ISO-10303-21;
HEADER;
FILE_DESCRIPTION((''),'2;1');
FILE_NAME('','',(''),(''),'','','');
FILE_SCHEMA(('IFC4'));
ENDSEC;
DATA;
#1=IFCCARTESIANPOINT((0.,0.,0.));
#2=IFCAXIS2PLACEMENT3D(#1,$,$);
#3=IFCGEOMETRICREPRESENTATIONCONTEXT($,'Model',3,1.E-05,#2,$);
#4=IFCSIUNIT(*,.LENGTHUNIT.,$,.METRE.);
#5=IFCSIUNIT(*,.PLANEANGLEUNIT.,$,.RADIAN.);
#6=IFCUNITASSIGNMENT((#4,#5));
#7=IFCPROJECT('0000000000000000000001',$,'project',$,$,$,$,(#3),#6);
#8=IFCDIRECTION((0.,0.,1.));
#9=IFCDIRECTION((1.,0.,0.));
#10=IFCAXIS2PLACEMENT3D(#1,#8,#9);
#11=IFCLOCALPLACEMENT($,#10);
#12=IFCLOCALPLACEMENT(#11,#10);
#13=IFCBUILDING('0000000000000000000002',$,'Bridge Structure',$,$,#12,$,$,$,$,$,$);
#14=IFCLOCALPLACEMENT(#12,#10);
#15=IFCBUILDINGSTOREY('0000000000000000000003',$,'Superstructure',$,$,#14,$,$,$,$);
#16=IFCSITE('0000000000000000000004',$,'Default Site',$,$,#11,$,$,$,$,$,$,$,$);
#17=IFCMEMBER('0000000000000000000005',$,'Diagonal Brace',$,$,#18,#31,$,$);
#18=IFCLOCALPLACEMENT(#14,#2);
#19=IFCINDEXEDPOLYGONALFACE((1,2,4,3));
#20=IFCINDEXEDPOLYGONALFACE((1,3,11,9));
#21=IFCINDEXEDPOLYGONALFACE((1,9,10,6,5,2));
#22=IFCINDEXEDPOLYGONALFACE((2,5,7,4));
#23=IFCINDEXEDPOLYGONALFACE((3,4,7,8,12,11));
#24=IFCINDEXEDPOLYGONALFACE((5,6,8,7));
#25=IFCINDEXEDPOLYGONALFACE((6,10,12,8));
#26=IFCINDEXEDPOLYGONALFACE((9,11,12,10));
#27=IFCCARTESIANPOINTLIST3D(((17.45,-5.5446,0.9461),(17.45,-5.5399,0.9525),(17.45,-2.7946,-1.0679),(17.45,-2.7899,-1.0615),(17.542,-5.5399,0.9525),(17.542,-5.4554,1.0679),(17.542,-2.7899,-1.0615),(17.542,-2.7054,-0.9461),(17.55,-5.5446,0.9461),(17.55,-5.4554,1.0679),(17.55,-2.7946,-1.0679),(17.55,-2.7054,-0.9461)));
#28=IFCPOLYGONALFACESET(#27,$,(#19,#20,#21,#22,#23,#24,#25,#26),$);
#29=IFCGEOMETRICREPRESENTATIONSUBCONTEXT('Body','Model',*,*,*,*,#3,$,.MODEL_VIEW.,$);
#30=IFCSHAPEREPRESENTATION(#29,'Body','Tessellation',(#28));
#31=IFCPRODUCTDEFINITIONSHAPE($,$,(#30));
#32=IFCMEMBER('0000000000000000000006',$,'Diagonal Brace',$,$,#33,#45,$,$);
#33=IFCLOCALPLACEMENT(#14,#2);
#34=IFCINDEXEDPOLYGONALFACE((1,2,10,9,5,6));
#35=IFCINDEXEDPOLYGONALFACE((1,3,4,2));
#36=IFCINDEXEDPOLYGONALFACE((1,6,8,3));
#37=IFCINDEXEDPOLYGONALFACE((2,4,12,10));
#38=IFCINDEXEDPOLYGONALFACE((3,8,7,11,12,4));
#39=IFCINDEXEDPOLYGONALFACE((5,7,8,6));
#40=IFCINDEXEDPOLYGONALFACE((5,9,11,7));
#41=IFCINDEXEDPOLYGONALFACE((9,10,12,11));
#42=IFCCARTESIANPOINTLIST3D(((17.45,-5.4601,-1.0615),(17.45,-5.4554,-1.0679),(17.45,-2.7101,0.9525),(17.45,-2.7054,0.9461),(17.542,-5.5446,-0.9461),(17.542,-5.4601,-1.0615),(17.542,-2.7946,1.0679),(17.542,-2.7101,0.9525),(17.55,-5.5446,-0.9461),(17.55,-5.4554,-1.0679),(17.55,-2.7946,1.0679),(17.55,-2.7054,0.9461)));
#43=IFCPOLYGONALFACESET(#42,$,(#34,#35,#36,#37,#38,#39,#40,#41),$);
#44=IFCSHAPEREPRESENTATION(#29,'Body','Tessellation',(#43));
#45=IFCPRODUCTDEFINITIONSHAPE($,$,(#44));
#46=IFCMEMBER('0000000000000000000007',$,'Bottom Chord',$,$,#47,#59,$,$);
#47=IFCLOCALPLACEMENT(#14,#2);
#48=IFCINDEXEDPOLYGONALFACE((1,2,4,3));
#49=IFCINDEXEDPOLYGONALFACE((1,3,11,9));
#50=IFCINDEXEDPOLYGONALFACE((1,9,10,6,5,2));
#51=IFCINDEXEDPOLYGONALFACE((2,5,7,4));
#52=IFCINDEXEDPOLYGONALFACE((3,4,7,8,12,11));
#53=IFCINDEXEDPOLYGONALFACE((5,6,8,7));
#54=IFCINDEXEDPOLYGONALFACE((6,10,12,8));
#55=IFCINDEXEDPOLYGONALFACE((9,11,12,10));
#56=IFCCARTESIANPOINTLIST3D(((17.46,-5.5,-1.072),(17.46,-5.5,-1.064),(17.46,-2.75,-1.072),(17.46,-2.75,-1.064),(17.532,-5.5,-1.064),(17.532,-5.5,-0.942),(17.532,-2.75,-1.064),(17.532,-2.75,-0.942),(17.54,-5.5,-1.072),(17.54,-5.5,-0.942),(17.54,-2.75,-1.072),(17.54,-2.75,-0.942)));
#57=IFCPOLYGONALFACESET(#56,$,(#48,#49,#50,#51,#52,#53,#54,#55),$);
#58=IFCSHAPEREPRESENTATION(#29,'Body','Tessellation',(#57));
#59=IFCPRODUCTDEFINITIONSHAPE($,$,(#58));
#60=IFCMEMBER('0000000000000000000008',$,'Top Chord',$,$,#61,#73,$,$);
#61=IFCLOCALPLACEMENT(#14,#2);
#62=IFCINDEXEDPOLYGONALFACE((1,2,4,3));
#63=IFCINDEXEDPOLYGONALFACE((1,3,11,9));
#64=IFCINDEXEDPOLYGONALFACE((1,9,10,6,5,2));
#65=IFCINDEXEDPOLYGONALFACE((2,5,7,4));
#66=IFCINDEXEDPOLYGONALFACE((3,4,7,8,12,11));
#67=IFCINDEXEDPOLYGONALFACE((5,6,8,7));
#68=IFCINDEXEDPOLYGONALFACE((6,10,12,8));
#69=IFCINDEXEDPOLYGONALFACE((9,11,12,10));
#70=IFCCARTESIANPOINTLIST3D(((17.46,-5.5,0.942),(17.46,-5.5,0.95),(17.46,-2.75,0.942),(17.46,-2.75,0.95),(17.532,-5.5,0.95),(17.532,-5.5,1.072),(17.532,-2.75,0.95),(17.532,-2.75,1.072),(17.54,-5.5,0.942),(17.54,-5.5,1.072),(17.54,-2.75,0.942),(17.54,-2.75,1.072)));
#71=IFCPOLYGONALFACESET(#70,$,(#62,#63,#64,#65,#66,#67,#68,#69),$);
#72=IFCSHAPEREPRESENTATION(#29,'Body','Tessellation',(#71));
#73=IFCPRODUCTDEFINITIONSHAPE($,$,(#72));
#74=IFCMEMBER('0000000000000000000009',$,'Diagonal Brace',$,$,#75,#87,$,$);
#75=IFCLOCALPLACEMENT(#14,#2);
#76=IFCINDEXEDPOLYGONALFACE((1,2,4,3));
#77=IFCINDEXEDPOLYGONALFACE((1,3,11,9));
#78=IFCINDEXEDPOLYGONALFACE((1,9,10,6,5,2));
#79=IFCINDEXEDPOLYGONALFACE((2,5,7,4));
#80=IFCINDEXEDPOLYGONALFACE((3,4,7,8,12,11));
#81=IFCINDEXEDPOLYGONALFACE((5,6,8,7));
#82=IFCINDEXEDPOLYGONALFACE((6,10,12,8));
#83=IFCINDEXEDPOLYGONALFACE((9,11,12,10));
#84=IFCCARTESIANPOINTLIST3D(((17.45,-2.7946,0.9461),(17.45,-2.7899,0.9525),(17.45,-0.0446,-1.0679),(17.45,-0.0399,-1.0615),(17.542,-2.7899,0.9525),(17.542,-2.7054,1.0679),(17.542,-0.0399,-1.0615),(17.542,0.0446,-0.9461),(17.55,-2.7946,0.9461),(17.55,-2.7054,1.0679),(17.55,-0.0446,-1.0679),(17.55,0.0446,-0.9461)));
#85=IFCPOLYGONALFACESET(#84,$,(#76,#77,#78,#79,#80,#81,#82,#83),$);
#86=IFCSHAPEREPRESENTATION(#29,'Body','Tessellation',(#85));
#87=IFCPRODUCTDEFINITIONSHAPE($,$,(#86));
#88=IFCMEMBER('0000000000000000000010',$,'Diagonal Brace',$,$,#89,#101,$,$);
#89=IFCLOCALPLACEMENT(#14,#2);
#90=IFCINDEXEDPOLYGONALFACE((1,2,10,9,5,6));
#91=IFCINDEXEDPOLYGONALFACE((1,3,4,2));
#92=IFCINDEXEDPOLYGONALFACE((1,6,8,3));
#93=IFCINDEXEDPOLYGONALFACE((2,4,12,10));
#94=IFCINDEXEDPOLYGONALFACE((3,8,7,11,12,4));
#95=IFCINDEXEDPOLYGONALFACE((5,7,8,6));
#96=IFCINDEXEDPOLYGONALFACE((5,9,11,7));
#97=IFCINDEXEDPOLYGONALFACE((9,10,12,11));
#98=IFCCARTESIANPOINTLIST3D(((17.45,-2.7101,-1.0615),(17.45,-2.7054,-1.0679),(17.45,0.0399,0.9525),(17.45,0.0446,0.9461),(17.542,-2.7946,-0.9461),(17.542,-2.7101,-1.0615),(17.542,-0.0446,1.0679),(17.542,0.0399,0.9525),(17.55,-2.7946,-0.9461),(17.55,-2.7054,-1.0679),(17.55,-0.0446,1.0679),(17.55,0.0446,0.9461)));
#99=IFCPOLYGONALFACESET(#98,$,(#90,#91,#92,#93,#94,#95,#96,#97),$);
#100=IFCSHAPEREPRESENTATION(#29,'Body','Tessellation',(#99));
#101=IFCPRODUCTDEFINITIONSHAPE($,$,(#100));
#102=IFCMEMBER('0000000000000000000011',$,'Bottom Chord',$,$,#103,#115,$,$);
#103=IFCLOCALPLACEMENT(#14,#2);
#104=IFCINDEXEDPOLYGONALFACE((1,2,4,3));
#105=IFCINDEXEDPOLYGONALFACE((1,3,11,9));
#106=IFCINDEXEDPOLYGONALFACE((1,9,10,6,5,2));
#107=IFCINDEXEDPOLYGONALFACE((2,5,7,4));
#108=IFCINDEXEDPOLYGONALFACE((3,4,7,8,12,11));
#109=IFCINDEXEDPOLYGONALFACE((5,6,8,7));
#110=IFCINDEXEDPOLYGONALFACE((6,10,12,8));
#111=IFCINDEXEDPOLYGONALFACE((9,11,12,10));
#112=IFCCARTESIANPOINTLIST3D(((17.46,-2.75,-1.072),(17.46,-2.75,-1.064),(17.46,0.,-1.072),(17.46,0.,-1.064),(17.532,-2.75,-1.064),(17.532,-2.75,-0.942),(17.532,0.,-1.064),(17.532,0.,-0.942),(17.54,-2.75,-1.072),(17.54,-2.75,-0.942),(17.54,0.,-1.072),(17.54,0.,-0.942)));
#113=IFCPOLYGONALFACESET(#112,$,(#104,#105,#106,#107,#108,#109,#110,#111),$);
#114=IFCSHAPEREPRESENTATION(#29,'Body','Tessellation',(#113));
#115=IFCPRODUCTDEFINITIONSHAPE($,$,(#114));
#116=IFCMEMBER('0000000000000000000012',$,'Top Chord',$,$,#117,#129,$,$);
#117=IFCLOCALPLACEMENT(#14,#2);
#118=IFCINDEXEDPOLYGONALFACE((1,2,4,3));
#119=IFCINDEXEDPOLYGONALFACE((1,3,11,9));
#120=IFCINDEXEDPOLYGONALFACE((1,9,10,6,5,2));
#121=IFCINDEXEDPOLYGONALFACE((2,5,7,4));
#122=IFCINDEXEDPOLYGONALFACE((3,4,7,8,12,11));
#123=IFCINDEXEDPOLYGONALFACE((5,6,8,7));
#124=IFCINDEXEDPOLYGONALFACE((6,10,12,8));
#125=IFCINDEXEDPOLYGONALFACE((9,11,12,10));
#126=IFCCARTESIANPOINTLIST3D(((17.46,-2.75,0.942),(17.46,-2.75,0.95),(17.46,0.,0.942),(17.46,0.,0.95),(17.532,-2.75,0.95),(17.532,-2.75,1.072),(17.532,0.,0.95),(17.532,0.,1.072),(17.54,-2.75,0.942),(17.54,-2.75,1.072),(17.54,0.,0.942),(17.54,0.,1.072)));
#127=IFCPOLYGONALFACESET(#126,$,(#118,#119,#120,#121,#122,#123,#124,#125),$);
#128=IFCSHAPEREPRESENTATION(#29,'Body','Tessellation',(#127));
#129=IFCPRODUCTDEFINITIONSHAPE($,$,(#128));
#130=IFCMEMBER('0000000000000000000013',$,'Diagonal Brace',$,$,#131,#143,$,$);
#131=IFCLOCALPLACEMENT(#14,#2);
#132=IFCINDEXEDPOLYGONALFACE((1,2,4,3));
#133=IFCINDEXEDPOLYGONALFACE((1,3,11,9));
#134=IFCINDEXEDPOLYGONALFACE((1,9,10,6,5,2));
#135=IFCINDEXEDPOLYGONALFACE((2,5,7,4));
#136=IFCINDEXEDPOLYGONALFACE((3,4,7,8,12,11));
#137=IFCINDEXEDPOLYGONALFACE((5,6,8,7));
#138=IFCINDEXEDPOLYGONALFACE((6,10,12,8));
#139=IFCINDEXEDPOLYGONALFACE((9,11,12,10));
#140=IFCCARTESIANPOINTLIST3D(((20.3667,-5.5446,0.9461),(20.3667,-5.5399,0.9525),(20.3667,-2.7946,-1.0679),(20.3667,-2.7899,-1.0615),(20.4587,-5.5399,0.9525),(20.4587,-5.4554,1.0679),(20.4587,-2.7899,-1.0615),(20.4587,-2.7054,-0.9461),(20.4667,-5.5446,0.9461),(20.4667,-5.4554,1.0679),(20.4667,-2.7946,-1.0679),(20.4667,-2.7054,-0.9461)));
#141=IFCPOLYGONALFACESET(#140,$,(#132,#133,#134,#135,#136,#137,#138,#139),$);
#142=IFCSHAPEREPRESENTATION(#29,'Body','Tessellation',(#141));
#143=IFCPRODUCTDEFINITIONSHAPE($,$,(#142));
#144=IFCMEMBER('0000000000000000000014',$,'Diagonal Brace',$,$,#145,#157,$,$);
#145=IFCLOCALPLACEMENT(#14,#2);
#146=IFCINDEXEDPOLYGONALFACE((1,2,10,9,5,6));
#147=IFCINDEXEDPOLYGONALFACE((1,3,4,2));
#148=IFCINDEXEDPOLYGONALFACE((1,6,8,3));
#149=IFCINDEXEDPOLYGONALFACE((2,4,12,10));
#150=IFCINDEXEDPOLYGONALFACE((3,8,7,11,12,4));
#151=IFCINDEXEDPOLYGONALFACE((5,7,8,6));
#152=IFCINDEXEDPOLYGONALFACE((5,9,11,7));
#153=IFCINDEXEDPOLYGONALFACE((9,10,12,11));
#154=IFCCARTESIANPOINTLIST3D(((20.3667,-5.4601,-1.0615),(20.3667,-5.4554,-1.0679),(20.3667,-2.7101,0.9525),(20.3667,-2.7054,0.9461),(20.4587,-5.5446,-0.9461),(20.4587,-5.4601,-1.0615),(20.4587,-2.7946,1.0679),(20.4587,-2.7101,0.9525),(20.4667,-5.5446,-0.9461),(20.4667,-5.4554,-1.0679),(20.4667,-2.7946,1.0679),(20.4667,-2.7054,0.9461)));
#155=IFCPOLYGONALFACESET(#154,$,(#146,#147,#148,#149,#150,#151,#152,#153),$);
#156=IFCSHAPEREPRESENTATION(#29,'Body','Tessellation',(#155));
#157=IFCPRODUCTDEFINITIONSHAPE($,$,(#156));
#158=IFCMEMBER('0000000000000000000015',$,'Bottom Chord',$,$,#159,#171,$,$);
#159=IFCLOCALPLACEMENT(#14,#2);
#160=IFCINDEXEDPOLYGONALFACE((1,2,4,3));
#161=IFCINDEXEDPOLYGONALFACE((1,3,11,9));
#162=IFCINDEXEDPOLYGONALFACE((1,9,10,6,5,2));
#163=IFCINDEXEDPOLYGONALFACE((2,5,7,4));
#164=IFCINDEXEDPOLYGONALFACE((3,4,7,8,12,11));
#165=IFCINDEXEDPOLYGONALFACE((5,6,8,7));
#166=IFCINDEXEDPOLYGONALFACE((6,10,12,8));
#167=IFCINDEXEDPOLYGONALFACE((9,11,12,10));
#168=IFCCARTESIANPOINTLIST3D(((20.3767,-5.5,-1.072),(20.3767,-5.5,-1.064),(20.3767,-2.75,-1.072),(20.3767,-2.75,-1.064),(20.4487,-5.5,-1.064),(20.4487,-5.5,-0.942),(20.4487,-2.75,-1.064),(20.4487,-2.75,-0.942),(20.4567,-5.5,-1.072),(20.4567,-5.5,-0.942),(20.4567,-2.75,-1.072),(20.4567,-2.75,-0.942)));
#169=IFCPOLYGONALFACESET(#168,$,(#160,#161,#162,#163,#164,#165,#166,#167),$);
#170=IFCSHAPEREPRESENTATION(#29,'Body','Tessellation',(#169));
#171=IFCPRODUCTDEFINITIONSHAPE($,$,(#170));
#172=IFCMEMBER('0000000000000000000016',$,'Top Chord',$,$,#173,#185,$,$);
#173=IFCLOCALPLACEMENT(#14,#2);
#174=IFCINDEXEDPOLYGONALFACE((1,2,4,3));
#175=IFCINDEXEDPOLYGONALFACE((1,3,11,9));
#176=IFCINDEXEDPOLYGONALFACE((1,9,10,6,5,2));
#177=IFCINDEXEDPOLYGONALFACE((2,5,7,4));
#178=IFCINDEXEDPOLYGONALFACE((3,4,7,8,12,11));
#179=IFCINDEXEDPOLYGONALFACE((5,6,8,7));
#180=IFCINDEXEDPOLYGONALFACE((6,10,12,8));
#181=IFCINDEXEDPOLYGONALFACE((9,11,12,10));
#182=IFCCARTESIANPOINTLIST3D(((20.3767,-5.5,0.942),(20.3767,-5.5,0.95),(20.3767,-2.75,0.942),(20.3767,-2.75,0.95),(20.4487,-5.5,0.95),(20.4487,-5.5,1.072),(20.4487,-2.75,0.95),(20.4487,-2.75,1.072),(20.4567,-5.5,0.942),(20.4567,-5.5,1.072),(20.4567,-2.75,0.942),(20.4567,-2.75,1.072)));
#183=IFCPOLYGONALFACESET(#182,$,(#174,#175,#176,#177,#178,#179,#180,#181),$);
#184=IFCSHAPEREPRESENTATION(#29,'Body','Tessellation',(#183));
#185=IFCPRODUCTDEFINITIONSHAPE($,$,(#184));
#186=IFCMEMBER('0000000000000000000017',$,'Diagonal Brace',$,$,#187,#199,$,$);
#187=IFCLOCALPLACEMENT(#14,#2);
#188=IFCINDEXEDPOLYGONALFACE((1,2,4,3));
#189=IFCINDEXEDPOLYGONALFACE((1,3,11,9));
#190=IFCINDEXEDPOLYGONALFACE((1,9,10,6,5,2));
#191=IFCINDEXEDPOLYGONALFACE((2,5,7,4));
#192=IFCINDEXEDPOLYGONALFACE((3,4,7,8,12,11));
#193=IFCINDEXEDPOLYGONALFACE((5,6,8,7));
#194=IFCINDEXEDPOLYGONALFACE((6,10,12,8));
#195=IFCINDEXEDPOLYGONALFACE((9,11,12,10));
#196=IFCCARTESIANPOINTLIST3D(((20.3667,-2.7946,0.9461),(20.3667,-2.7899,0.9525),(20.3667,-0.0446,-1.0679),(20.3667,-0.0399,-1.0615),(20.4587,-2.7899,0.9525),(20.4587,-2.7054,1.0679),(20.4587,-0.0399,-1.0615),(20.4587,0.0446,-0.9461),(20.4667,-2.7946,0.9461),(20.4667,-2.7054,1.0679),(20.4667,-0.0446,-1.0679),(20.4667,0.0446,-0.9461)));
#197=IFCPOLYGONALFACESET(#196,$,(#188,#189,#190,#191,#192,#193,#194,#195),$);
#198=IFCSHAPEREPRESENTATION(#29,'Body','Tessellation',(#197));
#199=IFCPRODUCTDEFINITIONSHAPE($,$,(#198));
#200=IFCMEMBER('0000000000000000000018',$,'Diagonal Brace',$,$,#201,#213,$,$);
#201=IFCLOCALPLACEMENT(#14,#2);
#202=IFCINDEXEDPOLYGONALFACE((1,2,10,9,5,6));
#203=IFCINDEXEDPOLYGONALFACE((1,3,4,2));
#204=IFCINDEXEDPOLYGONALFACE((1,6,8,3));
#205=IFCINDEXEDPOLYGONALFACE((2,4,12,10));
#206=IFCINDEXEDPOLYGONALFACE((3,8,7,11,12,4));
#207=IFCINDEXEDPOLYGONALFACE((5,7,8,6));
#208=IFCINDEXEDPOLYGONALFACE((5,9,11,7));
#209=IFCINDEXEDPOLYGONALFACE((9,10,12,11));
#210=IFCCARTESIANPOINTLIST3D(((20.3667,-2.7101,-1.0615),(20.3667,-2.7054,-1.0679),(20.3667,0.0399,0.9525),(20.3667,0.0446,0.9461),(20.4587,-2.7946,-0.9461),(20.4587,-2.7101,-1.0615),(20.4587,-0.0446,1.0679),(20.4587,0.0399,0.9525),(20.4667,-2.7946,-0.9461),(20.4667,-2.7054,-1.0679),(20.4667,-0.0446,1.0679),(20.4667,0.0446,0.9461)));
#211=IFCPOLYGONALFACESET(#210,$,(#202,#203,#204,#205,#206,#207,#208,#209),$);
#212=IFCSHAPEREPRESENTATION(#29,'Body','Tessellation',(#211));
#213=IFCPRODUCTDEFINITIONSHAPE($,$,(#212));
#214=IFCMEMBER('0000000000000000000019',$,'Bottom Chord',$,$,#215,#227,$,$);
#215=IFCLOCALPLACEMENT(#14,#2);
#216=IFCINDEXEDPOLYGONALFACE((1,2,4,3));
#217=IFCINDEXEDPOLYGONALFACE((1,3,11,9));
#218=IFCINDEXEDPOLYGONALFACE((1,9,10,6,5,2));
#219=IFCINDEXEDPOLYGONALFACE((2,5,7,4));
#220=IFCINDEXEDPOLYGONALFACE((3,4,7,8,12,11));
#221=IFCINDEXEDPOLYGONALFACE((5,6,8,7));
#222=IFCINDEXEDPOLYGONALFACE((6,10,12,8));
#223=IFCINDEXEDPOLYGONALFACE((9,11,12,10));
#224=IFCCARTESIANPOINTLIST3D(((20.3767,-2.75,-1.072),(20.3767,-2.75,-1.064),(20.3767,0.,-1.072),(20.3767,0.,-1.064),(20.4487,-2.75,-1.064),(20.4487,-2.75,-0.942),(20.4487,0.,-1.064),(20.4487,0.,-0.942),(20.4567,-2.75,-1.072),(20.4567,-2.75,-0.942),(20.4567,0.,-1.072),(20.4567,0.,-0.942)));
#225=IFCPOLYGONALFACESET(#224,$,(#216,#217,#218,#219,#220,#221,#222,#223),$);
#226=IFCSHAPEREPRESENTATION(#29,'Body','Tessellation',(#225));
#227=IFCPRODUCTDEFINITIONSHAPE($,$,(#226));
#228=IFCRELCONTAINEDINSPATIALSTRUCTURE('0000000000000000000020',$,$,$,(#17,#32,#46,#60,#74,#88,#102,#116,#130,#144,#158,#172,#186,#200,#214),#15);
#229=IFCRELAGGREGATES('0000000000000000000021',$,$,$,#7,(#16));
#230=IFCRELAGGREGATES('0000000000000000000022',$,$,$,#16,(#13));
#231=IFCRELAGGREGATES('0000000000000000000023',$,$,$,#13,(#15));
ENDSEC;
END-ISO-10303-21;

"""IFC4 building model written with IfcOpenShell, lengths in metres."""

from ifc_helpers import new_model, si_unit, frame, origin, origin_with_axes, origin_2d_with_axis, place, context, subcontext, project, spatial, l_section, extrude, element, save


model = new_model("IFC4")

# Units and contexts
model_context = context("Model", 3, precision=1e-05, world=origin())
body_context = subcontext(model_context, "Body", "Model", "MODEL_VIEW")
ifc_project = project(units=[si_unit("LENGTHUNIT", "METRE"), si_unit("PLANEANGLEUNIT", "RADIAN")], contexts=[model_context])

# Site, building, storey
site_placement = place(None, origin_with_axes())
site = spatial("IfcSite", under=ifc_project, at=site_placement, Name="Default Site")
building_placement = place(site_placement, origin_with_axes())
building = spatial("IfcBuilding", under=site, at=building_placement, Name="Bridge Structure")
storey_placement = place(building_placement, origin_with_axes())
storey = spatial("IfcBuildingStorey", under=building, at=storey_placement, Name="Superstructure")

# Members
for number, where, z_axis, x_axis, name in (
    (1, (17.5, -5.5, 1.007), (0.0, 0.806778, -0.590855), (-1.0, 0.0, 0.0), "Diagonal Brace"),
    (2, (17.5, -5.5, -1.007), (0.0, 0.806778, 0.590855), (-1.0, 0.0, 0.0), "Diagonal Brace"),
):
    element("IfcMember", number, at=place(storey_placement, frame(where, z_axis=z_axis, x_axis=x_axis)), inside=storey, Name=name, context=body_context, shape_type="SweptSolid", body=[
        extrude(l_section(Depth=0.151, Width=0.1, Thickness=0.008, at=origin_2d_with_axis()), origin_with_axes(), (0.0, 0.0, 1.0), 3.4086),
    ])
for number, where, z_axis, x_axis, name in (
    (3, (17.5, -5.5, -1.007), (0.0, 1.0, 0.0), (-1.0, 0.0, 0.0), "Bottom Chord"),
    (4, (17.5, -5.5, 1.007), (0.0, 1.0, 0.0), (-1.0, 0.0, 0.0), "Top Chord"),
):
    element("IfcMember", number, at=place(storey_placement, frame(where, z_axis=z_axis, x_axis=x_axis)), inside=storey, Name=name, context=body_context, shape_type="SweptSolid", body=[
        extrude(l_section(Depth=0.13, Width=0.08, Thickness=0.008, at=origin_2d_with_axis()), origin_with_axes(), (0.0, 0.0, 1.0), 2.75),
    ])
for number, where, z_axis, x_axis, name in (
    (5, (17.5, -2.75, 1.007), (0.0, 0.806778, -0.590855), (-1.0, 0.0, 0.0), "Diagonal Brace"),
    (6, (17.5, -2.75, -1.007), (0.0, 0.806778, 0.590855), (-1.0, 0.0, 0.0), "Diagonal Brace"),
):
    element("IfcMember", number, at=place(storey_placement, frame(where, z_axis=z_axis, x_axis=x_axis)), inside=storey, Name=name, context=body_context, shape_type="SweptSolid", body=[
        extrude(l_section(Depth=0.151, Width=0.1, Thickness=0.008, at=origin_2d_with_axis()), origin_with_axes(), (0.0, 0.0, 1.0), 3.4086),
    ])
for number, where, z_axis, x_axis, name in (
    (7, (17.5, -2.75, -1.007), (0.0, 1.0, 0.0), (-1.0, 0.0, 0.0), "Bottom Chord"),
    (8, (17.5, -2.75, 1.007), (0.0, 1.0, 0.0), (-1.0, 0.0, 0.0), "Top Chord"),
):
    element("IfcMember", number, at=place(storey_placement, frame(where, z_axis=z_axis, x_axis=x_axis)), inside=storey, Name=name, context=body_context, shape_type="SweptSolid", body=[
        extrude(l_section(Depth=0.13, Width=0.08, Thickness=0.008, at=origin_2d_with_axis()), origin_with_axes(), (0.0, 0.0, 1.0), 2.75),
    ])
for number, where, z_axis, x_axis, name in (
    (9, (20.4167, -5.5, 1.007), (0.0, 0.806778, -0.590855), (-1.0, 0.0, 0.0), "Diagonal Brace"),
    (10, (20.4167, -5.5, -1.007), (0.0, 0.806778, 0.590855), (-1.0, 0.0, 0.0), "Diagonal Brace"),
):
    element("IfcMember", number, at=place(storey_placement, frame(where, z_axis=z_axis, x_axis=x_axis)), inside=storey, Name=name, context=body_context, shape_type="SweptSolid", body=[
        extrude(l_section(Depth=0.151, Width=0.1, Thickness=0.008, at=origin_2d_with_axis()), origin_with_axes(), (0.0, 0.0, 1.0), 3.4086),
    ])
for number, where, z_axis, x_axis, name in (
    (11, (20.4167, -5.5, -1.007), (0.0, 1.0, 0.0), (-1.0, 0.0, 0.0), "Bottom Chord"),
    (12, (20.4167, -5.5, 1.007), (0.0, 1.0, 0.0), (-1.0, 0.0, 0.0), "Top Chord"),
):
    element("IfcMember", number, at=place(storey_placement, frame(where, z_axis=z_axis, x_axis=x_axis)), inside=storey, Name=name, context=body_context, shape_type="SweptSolid", body=[
        extrude(l_section(Depth=0.13, Width=0.08, Thickness=0.008, at=origin_2d_with_axis()), origin_with_axes(), (0.0, 0.0, 1.0), 2.75),
    ])
for number, where, z_axis, x_axis, name in (
    (13, (20.4167, -2.75, 1.007), (0.0, 0.806778, -0.590855), (-1.0, 0.0, 0.0), "Diagonal Brace"),
    (14, (20.4167, -2.75, -1.007), (0.0, 0.806778, 0.590855), (-1.0, 0.0, 0.0), "Diagonal Brace"),
):
    element("IfcMember", number, at=place(storey_placement, frame(where, z_axis=z_axis, x_axis=x_axis)), inside=storey, Name=name, context=body_context, shape_type="SweptSolid", body=[
        extrude(l_section(Depth=0.151, Width=0.1, Thickness=0.008, at=origin_2d_with_axis()), origin_with_axes(), (0.0, 0.0, 1.0), 3.4086),
    ])
member_placement = place(storey_placement, frame((20.4167, -2.75, -1.007), z_axis=(0.0, 1.0, 0.0), x_axis=(-1.0, 0.0, 0.0)))
element("IfcMember", 15, at=member_placement, inside=storey, Name="Bottom Chord", context=body_context, shape_type="SweptSolid", body=[
    extrude(l_section(Depth=0.13, Width=0.08, Thickness=0.008, at=origin_2d_with_axis()), origin_with_axes(), (0.0, 0.0, 1.0), 2.75),
])

save(model, "model.ifc")
